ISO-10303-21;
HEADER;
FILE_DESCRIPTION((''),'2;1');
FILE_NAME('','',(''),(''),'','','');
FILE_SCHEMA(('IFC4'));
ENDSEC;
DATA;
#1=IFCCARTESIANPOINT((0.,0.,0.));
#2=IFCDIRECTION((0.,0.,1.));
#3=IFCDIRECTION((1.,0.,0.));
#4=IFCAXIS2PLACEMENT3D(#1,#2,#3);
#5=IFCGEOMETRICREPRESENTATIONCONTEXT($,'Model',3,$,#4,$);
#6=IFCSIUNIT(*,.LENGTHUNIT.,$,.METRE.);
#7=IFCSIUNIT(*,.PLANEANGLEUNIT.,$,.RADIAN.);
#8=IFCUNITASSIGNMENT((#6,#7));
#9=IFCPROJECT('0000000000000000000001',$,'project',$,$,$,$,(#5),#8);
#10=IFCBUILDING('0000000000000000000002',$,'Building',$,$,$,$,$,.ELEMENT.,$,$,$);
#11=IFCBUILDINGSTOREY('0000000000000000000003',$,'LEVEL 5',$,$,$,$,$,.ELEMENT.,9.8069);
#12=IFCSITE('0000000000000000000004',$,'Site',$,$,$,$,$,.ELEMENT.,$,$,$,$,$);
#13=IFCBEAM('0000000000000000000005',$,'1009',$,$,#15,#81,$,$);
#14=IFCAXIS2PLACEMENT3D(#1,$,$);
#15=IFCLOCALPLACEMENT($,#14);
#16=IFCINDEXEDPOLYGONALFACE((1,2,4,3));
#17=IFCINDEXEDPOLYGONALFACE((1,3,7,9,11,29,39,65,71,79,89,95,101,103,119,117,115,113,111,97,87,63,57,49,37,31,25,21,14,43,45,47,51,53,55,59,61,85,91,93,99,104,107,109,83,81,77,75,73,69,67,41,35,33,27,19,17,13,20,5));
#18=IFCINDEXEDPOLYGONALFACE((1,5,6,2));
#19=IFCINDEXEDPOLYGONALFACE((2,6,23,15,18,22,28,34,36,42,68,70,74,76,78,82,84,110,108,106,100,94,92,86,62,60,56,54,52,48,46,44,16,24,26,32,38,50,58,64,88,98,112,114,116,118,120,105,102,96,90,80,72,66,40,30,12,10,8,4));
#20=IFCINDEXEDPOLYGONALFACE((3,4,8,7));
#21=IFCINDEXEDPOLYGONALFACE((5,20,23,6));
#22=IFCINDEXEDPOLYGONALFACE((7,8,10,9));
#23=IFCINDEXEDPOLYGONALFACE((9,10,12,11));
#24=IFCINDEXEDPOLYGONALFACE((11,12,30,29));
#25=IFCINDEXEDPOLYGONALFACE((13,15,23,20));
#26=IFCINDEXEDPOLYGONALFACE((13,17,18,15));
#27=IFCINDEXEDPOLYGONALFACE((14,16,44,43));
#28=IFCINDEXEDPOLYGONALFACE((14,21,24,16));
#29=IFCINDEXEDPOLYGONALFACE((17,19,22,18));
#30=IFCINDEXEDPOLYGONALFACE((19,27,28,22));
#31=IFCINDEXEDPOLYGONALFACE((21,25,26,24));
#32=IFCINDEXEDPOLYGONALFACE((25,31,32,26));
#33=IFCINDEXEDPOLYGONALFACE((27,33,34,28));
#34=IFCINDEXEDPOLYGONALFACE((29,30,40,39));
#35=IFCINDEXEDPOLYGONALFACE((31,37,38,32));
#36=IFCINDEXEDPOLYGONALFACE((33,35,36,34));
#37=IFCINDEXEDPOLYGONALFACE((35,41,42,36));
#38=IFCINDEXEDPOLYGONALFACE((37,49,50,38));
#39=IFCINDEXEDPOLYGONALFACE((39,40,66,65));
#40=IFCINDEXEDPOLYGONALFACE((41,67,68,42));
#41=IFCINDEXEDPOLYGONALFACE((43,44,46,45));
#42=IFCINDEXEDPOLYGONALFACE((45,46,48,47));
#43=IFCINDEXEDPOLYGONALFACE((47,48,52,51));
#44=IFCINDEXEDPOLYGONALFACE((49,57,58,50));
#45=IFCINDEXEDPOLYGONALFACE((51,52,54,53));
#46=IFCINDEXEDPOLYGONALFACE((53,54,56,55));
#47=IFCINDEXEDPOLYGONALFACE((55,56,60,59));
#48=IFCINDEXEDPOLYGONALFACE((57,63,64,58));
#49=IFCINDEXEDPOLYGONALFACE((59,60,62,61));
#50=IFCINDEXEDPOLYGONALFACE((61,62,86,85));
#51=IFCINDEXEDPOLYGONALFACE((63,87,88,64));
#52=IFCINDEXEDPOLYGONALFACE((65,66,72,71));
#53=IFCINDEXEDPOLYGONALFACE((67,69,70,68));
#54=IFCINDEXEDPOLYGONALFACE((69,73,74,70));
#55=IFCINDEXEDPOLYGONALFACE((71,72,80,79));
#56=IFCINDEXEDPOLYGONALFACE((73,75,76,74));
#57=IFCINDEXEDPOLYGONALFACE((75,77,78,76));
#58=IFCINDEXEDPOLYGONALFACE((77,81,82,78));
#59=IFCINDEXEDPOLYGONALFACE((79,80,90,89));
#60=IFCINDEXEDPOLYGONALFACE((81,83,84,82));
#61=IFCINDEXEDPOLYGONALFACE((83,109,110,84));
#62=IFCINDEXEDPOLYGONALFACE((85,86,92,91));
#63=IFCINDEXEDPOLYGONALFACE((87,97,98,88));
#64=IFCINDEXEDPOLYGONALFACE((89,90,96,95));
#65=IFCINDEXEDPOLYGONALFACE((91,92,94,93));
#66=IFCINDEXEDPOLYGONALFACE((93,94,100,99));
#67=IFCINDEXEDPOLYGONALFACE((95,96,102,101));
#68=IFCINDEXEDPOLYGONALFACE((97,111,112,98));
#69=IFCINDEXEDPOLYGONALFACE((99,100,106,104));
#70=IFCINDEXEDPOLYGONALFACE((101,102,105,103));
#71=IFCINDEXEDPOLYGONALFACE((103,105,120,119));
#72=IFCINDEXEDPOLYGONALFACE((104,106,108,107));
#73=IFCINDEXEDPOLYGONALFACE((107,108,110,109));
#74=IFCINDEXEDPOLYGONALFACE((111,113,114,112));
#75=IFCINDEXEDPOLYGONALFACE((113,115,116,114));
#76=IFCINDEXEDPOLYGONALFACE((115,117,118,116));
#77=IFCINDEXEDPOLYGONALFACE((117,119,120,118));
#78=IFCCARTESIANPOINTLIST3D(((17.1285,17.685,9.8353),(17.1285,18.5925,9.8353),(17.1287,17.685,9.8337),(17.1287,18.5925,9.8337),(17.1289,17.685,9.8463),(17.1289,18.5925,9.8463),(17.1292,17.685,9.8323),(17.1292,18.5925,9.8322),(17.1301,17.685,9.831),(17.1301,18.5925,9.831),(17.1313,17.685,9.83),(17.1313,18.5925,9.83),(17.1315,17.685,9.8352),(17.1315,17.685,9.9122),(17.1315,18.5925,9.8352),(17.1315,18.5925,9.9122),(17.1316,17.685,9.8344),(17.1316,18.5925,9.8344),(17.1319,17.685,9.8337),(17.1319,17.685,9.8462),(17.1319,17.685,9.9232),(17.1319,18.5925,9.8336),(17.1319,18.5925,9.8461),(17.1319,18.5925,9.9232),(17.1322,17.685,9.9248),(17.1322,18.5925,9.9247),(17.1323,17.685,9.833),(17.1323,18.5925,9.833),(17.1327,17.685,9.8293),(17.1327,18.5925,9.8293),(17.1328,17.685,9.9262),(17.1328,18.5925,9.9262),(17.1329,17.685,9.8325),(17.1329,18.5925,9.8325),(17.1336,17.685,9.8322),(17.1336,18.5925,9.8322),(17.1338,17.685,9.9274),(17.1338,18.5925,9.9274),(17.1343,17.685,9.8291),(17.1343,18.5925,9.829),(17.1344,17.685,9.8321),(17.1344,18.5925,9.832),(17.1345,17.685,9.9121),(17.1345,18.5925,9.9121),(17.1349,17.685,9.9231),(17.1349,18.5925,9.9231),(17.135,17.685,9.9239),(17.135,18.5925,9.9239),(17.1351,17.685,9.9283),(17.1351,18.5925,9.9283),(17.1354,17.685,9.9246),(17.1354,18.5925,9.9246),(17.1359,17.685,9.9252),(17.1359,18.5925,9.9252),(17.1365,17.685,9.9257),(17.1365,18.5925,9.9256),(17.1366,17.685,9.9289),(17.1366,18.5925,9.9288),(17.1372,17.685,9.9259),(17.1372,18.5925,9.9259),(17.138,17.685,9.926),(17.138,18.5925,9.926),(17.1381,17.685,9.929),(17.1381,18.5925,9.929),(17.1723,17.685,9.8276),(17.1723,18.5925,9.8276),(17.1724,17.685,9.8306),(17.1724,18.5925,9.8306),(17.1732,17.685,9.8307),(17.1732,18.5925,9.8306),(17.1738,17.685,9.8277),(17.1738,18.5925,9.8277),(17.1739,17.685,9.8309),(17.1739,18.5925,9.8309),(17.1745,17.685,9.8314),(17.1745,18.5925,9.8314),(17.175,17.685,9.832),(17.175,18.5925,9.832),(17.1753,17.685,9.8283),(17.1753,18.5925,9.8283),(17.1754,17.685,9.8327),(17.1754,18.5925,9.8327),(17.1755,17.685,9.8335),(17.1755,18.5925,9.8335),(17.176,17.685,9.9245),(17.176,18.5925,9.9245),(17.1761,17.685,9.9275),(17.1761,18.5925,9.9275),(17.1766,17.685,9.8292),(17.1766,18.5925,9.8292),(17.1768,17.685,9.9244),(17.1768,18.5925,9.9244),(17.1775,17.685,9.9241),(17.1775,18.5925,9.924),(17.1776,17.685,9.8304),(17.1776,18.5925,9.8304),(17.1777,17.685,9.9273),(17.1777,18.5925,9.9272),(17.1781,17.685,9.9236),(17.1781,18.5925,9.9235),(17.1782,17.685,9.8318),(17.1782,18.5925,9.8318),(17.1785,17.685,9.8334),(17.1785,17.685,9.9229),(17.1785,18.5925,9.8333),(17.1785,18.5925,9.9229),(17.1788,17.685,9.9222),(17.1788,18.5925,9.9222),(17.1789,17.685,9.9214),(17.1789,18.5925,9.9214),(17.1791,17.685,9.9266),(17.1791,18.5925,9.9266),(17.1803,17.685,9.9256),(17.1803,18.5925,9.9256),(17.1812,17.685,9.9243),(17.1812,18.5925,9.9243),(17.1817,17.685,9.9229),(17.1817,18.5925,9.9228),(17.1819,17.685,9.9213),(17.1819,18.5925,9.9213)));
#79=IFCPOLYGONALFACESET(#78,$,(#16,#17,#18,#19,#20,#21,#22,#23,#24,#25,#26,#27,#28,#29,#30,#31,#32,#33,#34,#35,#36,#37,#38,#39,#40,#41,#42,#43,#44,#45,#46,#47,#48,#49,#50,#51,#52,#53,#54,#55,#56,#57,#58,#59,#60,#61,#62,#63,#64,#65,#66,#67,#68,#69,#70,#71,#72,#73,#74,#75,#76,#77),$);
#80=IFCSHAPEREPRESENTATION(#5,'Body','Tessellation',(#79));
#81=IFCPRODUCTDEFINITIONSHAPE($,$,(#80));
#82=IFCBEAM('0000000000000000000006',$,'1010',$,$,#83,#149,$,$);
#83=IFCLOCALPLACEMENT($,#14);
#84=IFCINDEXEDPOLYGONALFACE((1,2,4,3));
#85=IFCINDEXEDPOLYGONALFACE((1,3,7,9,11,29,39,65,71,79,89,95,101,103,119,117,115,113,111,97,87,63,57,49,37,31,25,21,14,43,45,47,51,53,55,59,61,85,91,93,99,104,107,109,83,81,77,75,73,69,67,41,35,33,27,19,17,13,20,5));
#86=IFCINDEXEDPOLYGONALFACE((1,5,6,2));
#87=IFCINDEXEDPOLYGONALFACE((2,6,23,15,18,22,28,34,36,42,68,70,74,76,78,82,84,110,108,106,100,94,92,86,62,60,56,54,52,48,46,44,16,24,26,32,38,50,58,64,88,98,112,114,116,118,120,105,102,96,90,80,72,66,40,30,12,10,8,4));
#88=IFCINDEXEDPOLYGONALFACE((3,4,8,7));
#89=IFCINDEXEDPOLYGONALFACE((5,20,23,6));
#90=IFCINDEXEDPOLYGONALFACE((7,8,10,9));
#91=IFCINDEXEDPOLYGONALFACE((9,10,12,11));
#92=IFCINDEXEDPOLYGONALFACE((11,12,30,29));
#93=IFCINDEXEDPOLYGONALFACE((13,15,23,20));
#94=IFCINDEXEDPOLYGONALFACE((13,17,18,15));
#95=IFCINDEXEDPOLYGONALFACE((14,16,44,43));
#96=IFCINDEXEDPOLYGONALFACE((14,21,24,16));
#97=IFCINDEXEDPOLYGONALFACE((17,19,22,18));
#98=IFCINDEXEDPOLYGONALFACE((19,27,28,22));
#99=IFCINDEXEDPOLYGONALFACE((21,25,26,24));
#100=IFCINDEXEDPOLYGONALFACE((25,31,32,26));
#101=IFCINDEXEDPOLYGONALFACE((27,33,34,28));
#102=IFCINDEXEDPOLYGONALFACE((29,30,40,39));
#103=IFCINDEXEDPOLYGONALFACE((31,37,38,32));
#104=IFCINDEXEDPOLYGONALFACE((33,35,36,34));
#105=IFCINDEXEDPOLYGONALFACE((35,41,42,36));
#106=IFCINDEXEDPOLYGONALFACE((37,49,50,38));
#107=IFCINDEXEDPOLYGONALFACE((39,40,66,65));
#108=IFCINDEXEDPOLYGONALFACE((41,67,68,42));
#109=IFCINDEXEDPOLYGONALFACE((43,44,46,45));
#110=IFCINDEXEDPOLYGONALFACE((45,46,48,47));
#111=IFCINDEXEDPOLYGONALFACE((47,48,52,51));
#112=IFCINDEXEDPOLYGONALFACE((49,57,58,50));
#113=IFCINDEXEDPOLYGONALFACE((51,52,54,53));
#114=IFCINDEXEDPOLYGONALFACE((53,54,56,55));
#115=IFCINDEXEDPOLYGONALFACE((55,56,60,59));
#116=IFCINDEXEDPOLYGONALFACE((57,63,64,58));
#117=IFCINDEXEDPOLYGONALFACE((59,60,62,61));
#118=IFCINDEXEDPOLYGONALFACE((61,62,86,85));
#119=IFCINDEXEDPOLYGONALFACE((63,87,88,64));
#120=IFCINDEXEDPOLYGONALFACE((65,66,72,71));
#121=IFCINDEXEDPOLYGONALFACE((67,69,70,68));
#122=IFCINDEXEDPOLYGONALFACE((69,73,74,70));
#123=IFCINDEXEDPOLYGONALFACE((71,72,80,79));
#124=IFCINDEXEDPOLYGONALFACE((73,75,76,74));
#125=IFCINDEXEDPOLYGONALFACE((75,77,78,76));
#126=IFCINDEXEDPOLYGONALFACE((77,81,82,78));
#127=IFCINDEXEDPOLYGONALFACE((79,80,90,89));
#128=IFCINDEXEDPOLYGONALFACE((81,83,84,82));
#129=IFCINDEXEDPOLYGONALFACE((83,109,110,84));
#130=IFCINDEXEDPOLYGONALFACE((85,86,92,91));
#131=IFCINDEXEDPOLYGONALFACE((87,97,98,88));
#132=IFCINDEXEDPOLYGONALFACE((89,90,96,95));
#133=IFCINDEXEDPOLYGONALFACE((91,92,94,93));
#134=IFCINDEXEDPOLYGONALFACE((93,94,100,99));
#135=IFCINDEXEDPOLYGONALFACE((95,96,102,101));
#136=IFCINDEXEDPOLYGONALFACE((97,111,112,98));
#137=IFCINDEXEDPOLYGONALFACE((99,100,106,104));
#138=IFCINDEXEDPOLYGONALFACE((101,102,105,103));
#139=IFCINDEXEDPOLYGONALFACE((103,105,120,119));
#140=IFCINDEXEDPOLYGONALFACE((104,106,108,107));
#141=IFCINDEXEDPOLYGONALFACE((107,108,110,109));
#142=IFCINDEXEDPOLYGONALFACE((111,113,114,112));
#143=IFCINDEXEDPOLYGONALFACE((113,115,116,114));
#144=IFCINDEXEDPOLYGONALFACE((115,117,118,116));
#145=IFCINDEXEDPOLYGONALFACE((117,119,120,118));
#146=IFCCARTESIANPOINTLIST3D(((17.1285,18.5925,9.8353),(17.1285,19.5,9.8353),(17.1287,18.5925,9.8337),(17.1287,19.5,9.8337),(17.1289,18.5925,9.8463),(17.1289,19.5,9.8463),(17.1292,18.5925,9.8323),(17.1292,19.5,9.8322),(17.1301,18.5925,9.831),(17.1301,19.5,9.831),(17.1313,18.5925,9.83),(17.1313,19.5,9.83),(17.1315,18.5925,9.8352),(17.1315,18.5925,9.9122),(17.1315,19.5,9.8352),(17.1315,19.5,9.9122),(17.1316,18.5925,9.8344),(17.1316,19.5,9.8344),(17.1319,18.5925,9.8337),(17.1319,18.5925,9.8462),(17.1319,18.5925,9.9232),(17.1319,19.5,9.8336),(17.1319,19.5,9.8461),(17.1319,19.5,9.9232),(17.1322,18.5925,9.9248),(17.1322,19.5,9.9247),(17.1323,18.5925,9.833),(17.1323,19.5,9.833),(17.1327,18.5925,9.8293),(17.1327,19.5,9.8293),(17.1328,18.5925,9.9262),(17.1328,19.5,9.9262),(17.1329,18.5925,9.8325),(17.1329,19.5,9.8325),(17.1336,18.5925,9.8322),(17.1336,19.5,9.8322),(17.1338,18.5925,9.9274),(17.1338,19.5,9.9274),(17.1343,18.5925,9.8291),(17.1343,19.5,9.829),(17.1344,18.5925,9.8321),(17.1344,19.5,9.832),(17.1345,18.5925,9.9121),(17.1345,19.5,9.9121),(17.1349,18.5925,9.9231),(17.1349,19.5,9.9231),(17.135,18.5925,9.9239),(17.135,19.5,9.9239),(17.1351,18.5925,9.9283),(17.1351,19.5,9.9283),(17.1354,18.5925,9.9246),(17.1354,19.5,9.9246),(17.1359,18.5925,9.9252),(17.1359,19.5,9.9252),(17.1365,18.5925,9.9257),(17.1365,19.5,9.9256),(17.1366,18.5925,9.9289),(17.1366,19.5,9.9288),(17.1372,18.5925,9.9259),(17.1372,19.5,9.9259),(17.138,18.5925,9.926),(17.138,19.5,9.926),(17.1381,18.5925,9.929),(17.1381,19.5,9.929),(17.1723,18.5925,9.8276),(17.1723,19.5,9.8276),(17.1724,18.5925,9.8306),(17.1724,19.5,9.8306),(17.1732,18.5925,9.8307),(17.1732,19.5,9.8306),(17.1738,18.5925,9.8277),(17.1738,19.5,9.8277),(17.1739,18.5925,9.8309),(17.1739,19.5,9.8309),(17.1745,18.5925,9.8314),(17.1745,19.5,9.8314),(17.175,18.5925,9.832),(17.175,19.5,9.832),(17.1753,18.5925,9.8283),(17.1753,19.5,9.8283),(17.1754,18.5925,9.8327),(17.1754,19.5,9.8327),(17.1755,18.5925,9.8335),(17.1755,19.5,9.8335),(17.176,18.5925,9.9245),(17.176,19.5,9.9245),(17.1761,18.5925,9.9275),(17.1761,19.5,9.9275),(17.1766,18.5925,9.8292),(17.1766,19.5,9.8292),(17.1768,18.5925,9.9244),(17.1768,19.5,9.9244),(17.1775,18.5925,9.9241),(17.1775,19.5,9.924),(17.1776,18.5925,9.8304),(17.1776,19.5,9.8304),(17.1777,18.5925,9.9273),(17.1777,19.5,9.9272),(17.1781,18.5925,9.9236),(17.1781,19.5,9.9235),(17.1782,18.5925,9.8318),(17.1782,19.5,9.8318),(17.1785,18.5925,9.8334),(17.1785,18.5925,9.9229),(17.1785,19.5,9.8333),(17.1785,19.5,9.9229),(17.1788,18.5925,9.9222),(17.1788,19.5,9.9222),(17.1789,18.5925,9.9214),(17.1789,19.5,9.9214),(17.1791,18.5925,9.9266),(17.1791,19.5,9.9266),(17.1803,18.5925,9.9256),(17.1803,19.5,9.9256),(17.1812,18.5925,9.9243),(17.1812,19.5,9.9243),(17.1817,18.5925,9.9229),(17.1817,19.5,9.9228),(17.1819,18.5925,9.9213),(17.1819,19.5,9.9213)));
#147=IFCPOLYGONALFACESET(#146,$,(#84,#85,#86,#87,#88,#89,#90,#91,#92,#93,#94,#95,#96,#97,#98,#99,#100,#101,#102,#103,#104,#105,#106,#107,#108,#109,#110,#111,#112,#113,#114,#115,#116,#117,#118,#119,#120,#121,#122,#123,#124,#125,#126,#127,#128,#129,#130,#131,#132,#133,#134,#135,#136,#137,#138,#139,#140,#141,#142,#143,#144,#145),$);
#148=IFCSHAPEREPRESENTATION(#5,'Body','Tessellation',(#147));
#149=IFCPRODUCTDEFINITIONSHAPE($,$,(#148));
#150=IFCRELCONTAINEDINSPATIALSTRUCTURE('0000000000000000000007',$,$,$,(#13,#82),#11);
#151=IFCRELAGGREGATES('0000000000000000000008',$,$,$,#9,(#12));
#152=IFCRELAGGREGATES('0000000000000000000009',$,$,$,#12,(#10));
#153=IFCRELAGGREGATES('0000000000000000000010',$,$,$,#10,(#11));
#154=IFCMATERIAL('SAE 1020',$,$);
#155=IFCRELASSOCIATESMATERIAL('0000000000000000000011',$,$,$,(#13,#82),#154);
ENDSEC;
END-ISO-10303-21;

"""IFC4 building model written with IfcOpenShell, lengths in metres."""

from ifc_helpers import new_model, si_unit, frame, origin_with_axes, origin_2d_with_axis, place, context, project, spatial, c_section, extrude, material, material_profile, profile_set, profile_usage, element, save


model = new_model("IFC4")

# Units and contexts
model_context = context("Model", 3, world=origin_with_axes())
ifc_project = project(units=[si_unit("LENGTHUNIT", "METRE"), si_unit("PLANEANGLEUNIT", "RADIAN")], contexts=[model_context])

# Site, building, storey
site = spatial("IfcSite", under=ifc_project, Name="Site", CompositionType="ELEMENT")
building = spatial("IfcBuilding", under=site, Name="Building", CompositionType="ELEMENT")
storey = spatial("IfcBuildingStorey", under=building, Name="LEVEL 5", CompositionType="ELEMENT", Elevation=9.8069)

# Beams
ifc_material = material(Name="SAE 1020")
ifc_material_profile_1 = material_profile(ifc_material, c_section(Depth=0.1, Width=0.05, WallThickness=0.003, Girth=0.017, InternalFilletRadius=0.003, at=origin_2d_with_axis()))
ifc_profile_set_1 = profile_set([ifc_material_profile_1])
ifc_profile_usage_1 = profile_usage(ifc_profile_set_1, cardinal=10)
beam_1_placement = place(None, frame((17.1552, 17.685, 9.8783), z_axis=(0.0, 1.0, -0.00003), x_axis=(-0.999256, 0.000001, 0.038562)))
element("IfcBeam", 1, at=beam_1_placement, inside=storey, material=ifc_profile_usage_1, Name="1009", context=model_context, shape_type="SweptSolid", body=[
    extrude(c_section(Depth=0.1, Width=0.05, WallThickness=0.003, Girth=0.017, InternalFilletRadius=0.003, at=origin_2d_with_axis()), origin_with_axes(), (0.0, 0.0, 1.0), 0.9075),
])
ifc_material_profile_2 = material_profile(ifc_material, c_section(Depth=0.1, Width=0.05, WallThickness=0.003, Girth=0.017, InternalFilletRadius=0.003, at=origin_2d_with_axis()))
ifc_profile_set_2 = profile_set([ifc_material_profile_2])
ifc_profile_usage_2 = profile_usage(ifc_profile_set_2, cardinal=10)
beam_2_placement = place(None, frame((17.1552, 18.5925, 9.8783), z_axis=(0.0, 1.0, -0.00003), x_axis=(-0.999256, 0.000001, 0.038562)))
element("IfcBeam", 2, at=beam_2_placement, inside=storey, material=ifc_profile_usage_2, Name="1010", context=model_context, shape_type="SweptSolid", body=[
    extrude(c_section(Depth=0.1, Width=0.05, WallThickness=0.003, Girth=0.017, InternalFilletRadius=0.003, at=origin_2d_with_axis()), origin_with_axes(), (0.0, 0.0, 1.0), 0.9075),
])

save(model, "model.ifc")
